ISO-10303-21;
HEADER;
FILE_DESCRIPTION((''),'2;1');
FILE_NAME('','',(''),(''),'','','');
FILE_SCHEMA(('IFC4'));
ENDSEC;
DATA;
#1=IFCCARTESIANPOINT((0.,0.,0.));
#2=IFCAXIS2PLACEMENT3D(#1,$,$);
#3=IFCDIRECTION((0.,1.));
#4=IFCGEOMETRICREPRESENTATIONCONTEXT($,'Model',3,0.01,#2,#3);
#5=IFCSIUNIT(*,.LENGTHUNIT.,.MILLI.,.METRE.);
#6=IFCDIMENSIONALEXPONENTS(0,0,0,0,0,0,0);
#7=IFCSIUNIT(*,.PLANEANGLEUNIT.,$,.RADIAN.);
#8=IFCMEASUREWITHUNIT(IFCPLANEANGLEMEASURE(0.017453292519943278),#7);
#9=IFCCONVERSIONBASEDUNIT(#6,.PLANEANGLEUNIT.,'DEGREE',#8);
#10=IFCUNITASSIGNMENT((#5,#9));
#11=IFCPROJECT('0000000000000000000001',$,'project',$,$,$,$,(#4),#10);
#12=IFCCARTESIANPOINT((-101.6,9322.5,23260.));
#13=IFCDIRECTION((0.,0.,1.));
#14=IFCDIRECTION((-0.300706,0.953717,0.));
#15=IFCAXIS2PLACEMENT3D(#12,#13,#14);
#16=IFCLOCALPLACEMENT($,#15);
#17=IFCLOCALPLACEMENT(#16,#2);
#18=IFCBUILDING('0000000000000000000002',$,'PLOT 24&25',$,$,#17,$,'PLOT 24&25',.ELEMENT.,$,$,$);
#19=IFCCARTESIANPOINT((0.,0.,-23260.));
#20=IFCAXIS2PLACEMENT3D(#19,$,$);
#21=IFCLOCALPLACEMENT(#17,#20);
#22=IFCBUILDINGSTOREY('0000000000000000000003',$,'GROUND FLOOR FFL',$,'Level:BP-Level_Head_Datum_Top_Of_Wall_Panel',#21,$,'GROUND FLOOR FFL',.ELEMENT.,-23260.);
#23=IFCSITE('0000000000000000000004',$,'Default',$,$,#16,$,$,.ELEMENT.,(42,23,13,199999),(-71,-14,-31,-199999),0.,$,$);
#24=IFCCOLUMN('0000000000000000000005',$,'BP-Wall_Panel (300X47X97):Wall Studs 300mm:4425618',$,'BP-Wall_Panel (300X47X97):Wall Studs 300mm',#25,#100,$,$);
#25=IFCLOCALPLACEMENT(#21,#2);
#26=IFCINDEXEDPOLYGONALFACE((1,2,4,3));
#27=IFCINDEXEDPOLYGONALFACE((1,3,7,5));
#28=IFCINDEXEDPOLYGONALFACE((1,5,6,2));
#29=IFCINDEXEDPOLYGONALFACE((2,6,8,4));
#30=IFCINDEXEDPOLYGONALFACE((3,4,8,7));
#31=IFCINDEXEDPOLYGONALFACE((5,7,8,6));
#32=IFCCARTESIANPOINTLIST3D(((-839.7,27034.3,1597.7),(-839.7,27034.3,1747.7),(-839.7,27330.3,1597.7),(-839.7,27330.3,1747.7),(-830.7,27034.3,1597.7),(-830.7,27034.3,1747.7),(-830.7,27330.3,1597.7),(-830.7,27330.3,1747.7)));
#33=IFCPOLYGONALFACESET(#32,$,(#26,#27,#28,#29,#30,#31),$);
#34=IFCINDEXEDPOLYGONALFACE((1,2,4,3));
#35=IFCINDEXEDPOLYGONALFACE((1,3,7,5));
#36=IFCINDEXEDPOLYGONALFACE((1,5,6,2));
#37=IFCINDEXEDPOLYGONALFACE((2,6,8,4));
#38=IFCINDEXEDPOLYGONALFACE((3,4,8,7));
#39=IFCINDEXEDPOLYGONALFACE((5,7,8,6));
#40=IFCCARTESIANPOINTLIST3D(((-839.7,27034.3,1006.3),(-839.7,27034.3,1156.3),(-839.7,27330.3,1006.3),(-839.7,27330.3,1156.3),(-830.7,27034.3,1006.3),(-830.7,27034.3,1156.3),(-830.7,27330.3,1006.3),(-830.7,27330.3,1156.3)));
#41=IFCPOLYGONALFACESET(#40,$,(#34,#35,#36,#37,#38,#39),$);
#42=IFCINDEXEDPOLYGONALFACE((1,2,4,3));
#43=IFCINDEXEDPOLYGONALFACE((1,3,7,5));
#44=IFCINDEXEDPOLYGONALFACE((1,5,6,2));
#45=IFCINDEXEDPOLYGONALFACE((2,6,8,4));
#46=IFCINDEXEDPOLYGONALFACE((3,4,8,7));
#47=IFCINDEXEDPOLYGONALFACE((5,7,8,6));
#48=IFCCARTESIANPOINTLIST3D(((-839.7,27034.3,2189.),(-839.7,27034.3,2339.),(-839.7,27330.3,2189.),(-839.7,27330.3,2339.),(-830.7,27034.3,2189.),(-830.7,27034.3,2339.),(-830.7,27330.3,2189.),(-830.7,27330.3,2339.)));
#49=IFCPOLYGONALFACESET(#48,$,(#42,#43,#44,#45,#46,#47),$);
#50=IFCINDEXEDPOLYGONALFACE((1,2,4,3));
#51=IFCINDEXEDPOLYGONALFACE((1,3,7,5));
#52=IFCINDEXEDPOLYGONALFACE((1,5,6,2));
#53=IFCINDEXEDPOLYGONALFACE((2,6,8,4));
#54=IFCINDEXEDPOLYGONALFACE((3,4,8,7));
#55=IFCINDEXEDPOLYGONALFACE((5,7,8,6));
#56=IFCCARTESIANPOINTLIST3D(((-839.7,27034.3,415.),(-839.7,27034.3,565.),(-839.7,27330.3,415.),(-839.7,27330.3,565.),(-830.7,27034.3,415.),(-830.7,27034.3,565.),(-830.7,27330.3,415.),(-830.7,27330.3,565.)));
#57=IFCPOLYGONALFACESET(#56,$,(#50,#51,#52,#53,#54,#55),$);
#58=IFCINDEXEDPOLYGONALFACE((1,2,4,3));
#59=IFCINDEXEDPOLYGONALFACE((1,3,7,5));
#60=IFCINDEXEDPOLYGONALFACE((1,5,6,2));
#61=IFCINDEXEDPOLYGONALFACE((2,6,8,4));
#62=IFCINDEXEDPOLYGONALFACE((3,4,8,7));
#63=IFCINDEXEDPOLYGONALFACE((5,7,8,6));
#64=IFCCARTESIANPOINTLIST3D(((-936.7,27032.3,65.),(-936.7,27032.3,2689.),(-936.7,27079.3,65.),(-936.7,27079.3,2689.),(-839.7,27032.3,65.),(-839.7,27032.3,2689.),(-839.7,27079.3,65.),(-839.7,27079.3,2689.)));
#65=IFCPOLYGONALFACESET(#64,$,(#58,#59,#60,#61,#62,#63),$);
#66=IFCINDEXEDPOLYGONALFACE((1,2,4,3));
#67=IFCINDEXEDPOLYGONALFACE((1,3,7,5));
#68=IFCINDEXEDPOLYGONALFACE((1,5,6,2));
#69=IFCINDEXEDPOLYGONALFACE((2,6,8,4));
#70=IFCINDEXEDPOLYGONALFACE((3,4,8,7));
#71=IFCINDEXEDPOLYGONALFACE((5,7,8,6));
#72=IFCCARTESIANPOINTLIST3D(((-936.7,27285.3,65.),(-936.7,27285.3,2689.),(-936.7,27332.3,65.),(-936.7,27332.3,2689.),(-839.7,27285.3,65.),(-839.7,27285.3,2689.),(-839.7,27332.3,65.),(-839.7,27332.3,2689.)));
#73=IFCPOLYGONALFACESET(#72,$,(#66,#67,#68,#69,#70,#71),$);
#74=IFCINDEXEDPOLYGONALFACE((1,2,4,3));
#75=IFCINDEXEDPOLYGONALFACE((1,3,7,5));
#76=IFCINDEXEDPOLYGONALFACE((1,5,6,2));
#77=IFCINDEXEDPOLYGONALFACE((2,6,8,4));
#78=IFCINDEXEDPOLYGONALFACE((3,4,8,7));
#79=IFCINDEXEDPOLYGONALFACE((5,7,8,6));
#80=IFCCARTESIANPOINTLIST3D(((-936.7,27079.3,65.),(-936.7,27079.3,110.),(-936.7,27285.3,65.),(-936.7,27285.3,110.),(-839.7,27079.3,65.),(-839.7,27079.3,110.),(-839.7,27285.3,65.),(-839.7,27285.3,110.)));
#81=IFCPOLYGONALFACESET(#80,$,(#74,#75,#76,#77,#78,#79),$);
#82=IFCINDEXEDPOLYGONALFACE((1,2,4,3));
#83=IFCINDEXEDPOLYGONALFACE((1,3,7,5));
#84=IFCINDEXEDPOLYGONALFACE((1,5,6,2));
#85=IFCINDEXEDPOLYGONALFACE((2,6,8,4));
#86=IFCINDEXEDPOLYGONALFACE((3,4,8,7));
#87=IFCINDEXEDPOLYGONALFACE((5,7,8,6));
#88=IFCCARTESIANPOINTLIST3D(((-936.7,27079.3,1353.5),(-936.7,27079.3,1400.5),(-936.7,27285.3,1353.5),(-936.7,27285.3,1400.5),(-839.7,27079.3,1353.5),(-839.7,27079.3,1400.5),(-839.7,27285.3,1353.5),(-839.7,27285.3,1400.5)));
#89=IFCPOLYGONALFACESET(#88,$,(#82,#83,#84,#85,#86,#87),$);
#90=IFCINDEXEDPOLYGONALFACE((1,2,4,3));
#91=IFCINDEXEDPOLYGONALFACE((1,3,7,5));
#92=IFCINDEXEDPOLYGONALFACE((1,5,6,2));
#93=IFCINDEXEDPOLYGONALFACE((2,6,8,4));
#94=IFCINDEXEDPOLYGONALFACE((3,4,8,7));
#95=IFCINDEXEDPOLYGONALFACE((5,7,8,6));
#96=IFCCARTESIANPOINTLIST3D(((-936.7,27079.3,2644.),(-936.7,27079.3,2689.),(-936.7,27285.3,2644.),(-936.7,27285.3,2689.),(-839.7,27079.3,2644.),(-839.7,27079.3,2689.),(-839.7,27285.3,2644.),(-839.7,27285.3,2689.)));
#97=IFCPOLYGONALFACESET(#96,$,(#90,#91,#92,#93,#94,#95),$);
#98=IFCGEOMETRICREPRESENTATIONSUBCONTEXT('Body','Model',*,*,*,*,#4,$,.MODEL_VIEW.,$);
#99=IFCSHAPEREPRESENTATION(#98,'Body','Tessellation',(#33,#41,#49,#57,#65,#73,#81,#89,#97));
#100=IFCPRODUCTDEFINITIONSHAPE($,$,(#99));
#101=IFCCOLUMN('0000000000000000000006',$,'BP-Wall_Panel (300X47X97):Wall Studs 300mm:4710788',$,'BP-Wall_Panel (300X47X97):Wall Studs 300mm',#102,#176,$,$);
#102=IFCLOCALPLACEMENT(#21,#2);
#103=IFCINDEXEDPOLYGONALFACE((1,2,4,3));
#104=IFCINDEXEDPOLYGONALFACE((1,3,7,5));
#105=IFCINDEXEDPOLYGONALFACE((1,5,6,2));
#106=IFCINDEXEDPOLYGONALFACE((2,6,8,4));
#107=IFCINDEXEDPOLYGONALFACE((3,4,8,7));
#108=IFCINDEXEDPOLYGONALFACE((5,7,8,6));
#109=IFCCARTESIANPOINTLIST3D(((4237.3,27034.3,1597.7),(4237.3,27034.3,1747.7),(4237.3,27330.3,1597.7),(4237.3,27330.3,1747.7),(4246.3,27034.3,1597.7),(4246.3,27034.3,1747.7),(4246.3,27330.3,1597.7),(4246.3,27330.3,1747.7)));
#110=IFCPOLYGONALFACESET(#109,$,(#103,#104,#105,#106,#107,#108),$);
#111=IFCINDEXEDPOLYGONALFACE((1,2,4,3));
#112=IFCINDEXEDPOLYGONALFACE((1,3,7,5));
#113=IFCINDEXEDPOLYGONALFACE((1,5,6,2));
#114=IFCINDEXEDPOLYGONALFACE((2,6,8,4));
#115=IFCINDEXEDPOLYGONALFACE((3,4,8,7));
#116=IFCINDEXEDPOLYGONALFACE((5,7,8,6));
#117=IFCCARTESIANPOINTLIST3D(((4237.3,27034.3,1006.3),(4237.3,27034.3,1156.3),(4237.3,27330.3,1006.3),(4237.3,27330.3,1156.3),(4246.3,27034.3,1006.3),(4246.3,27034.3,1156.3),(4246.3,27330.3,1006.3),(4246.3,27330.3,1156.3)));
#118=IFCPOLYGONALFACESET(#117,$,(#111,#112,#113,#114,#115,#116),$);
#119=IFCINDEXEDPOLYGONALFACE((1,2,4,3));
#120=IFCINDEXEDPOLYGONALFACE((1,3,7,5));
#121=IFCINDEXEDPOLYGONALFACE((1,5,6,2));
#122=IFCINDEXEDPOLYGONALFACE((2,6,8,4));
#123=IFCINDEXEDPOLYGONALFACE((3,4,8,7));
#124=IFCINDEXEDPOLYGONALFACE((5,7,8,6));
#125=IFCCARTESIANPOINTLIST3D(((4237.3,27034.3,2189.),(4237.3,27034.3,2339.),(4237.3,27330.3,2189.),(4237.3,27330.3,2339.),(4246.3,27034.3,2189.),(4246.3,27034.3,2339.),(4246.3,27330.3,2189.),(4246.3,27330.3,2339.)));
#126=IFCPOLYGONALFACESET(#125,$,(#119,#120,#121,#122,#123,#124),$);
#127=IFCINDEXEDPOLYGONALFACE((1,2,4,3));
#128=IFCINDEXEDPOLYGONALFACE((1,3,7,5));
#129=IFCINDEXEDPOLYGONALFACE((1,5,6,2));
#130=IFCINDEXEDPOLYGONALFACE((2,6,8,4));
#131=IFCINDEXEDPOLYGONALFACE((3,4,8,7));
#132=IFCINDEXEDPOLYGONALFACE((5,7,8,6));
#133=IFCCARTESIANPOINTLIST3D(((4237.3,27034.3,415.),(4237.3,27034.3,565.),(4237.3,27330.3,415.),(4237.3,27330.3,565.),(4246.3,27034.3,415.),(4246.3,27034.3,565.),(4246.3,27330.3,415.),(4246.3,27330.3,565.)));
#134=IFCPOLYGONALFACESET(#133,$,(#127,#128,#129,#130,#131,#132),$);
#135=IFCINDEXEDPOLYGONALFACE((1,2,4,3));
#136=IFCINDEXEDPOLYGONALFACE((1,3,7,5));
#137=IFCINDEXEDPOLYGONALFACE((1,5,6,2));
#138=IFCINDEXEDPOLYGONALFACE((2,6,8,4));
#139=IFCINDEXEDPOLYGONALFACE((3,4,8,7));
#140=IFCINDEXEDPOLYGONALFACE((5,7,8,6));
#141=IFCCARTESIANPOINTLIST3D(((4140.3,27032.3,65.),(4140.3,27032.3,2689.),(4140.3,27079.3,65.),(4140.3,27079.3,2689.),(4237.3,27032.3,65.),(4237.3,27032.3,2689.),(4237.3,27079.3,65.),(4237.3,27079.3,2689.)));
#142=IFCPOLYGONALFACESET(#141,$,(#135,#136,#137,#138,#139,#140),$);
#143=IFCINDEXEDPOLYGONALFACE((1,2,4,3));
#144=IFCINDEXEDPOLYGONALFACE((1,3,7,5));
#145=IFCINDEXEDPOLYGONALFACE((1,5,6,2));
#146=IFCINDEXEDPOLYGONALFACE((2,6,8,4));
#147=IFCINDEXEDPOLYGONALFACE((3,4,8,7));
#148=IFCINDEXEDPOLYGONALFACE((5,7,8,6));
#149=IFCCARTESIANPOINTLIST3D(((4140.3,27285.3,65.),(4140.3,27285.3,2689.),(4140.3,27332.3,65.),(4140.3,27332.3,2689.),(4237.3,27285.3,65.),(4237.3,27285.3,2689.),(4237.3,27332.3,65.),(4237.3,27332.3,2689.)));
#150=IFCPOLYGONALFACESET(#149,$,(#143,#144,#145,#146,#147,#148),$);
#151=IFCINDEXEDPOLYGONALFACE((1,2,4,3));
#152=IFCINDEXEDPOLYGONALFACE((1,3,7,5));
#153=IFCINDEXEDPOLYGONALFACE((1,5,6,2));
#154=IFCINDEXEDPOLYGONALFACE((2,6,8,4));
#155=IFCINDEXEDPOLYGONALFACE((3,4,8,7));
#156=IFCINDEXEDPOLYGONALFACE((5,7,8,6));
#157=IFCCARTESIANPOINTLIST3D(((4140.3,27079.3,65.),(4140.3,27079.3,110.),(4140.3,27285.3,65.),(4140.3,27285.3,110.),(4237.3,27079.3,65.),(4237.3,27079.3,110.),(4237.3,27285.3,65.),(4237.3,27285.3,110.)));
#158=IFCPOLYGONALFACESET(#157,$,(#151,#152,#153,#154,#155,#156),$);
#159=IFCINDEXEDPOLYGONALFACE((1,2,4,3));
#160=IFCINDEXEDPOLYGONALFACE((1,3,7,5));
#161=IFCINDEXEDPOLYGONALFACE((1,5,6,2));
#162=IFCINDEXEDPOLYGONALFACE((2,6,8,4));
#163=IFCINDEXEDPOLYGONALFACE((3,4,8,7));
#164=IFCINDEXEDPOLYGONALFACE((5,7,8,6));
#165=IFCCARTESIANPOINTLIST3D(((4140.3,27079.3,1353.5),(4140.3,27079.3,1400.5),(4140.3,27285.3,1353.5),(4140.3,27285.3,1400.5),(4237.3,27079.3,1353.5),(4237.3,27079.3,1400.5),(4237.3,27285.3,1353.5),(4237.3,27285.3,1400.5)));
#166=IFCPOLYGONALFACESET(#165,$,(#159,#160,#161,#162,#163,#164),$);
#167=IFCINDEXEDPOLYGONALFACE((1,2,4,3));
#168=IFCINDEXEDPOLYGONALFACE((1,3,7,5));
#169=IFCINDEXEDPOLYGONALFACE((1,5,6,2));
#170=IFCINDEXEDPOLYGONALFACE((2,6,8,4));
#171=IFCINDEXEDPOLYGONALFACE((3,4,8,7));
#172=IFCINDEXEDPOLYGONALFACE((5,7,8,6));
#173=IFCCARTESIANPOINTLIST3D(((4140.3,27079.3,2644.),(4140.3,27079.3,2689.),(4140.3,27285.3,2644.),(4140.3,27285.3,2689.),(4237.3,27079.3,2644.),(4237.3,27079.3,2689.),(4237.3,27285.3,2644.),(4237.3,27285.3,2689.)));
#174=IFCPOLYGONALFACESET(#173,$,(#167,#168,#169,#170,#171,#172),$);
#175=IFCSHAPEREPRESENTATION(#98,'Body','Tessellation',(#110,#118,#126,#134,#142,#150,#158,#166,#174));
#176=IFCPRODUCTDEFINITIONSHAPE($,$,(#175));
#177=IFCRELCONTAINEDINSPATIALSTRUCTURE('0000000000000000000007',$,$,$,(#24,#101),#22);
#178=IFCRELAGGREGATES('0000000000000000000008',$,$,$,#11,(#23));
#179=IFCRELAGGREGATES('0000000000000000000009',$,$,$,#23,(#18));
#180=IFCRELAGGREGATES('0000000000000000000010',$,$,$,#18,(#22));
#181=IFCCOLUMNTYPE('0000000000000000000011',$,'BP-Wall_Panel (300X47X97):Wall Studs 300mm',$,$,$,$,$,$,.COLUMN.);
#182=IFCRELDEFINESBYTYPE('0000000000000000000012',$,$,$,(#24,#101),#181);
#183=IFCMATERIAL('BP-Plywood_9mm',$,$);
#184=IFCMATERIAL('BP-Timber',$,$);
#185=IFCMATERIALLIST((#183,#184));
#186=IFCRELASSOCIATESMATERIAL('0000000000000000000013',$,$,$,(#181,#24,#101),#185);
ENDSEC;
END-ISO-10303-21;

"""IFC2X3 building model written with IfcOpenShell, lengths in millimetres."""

from ifc_helpers import new_model, entity, si_unit, converted_unit, direction, frame, frame_2d, origin, origin_2d_with_axis, place, context, subcontext, project, spatial, rectangle, extrude, source, transform, mapped, material, material_list, type_object, type_shapes, element, save


model = new_model("IFC2X3")

# Units and contexts
model_context = context("Model", 3, precision=0.01, world=origin(), true_north=direction((0.0, 1.0)))
body_context = subcontext(model_context, "Body", "Model", "MODEL_VIEW")
ifc_project = project(units=[si_unit("LENGTHUNIT", "METRE", prefix="MILLI"), converted_unit("PLANEANGLEUNIT", "DEGREE", entity("IfcPlaneAngleMeasure", 0.017453292519943278), si_unit("PLANEANGLEUNIT", "RADIAN"), dimensions=[0, 0, 0, 0, 0, 0, 0])], contexts=[model_context])

# Site, building, storey
site_placement = place(None, frame((-101.6, 9322.5, 23260.0), z_axis=(0.0, 0.0, 1.0), x_axis=(-0.300706, 0.953717, 0.0)))
site = spatial("IfcSite", under=ifc_project, at=site_placement, Name="Default", CompositionType="ELEMENT", RefLatitude=(42, 23, 13, 199999), RefLongitude=(-71, -14, -31, -199999), RefElevation=0.0)
building_placement = place(site_placement, origin())
building = spatial("IfcBuilding", under=site, at=building_placement, Name="PLOT 24&25", LongName="PLOT 24&25", CompositionType="ELEMENT")
storey_placement = place(building_placement, frame((0.0, 0.0, -23260.0)))
storey = spatial("IfcBuildingStorey", under=building, at=storey_placement, Name="GROUND FLOOR FFL", ObjectType="Level:BP-Level_Head_Datum_Top_Of_Wall_Panel", LongName="GROUND FLOOR FFL", CompositionType="ELEMENT", Elevation=-23260.0)

# Columns
ifc_material_1 = material(Name="BP-Plywood_9mm")
ifc_material_2 = material(Name="BP-Timber")
ifc_material_list = material_list([ifc_material_1, ifc_material_2])
column_type_1 = type_object("IfcColumnType", Name="BP-Wall_Panel (300X47X97):Wall Studs 300mm", PredefinedType="COLUMN", material=ifc_material_list)
shared_shape_1 = source(origin(), body_context, "Body", "SweptSolid", [
    extrude(rectangle(XDim=296.0, YDim=9.0, at=origin_2d_with_axis()), frame((53.0, 0.0, -21662.3), z_axis=(0.0, 0.0, 1.0), x_axis=(0.0, -1.0, 0.0)), (0.0, 0.0, 1.0), 150.0),
    extrude(rectangle(XDim=296.0, YDim=9.0, at=origin_2d_with_axis()), frame((53.0, 0.0, -22253.7), z_axis=(0.0, 0.0, 1.0), x_axis=(0.0, -1.0, 0.0)), (0.0, 0.0, 1.0), 150.0),
    extrude(rectangle(XDim=296.0, YDim=9.0, at=origin_2d_with_axis()), frame((53.0, 0.0, -21071.0), z_axis=(0.0, 0.0, 1.0), x_axis=(0.0, -1.0, 0.0)), (0.0, 0.0, 1.0), 150.0),
    extrude(rectangle(XDim=296.0, YDim=9.0, at=origin_2d_with_axis()), frame((53.0, 0.0, -22845.0), z_axis=(0.0, 0.0, 1.0), x_axis=(0.0, -1.0, 0.0)), (0.0, 0.0, 1.0), 150.0),
    extrude(rectangle(XDim=97.0, YDim=47.0, at=origin_2d_with_axis()), frame((0.0, -126.5, -23195.0), z_axis=(0.0, 0.0, 1.0), x_axis=(-1.0, 0.0, 0.0)), (0.0, 0.0, 1.0), 2624.0),
    extrude(rectangle(XDim=97.0, YDim=47.0, at=frame_2d((0.0, 0.0), x_axis=(1.0, 0.0))), frame((0.0, 126.5, -23195.0), z_axis=(0.0, 0.0, 1.0), x_axis=(-1.0, 0.0, 0.0)), (0.0, 0.0, 1.0), 2624.0),
    extrude(rectangle(XDim=206.0, YDim=97.0, at=origin_2d_with_axis()), frame((0.0, 0.0, -23195.0), z_axis=(0.0, 0.0, 1.0), x_axis=(0.0, -1.0, 0.0)), (0.0, 0.0, 1.0), 45.0),
    extrude(rectangle(XDim=206.0, YDim=97.0, at=origin_2d_with_axis()), frame((0.0, 0.0, -21906.5), z_axis=(0.0, 0.0, 1.0), x_axis=(0.0, -1.0, 0.0)), (0.0, 0.0, 1.0), 47.0),
    extrude(rectangle(XDim=206.0, YDim=97.0, at=origin_2d_with_axis()), frame((0.0, 0.0, -20616.0), z_axis=(0.0, 0.0, 1.0), x_axis=(0.0, -1.0, 0.0)), (0.0, 0.0, 1.0), 45.0),
])
type_shapes(column_type_1, [shared_shape_1])
for number, where, name in (
    (1, (-888.2, 27182.3, 23260.0), "BP-Wall_Panel (300X47X97):Wall Studs 300mm:4425618"),
    (2, (4188.8, 27182.3, 23260.0), "BP-Wall_Panel (300X47X97):Wall Studs 300mm:4710788"),
):
    element("IfcColumn", number, at=place(storey_placement, frame(where)), inside=storey, type_object=column_type_1, material=ifc_material_list, Name=name, ObjectType="BP-Wall_Panel (300X47X97):Wall Studs 300mm", context=body_context, shape_type="MappedRepresentation", body=[
        mapped(shared_shape_1, transform((0.0, 0.0, 0.0), scale=1.0)),
    ])

save(model, "model.ifc")
